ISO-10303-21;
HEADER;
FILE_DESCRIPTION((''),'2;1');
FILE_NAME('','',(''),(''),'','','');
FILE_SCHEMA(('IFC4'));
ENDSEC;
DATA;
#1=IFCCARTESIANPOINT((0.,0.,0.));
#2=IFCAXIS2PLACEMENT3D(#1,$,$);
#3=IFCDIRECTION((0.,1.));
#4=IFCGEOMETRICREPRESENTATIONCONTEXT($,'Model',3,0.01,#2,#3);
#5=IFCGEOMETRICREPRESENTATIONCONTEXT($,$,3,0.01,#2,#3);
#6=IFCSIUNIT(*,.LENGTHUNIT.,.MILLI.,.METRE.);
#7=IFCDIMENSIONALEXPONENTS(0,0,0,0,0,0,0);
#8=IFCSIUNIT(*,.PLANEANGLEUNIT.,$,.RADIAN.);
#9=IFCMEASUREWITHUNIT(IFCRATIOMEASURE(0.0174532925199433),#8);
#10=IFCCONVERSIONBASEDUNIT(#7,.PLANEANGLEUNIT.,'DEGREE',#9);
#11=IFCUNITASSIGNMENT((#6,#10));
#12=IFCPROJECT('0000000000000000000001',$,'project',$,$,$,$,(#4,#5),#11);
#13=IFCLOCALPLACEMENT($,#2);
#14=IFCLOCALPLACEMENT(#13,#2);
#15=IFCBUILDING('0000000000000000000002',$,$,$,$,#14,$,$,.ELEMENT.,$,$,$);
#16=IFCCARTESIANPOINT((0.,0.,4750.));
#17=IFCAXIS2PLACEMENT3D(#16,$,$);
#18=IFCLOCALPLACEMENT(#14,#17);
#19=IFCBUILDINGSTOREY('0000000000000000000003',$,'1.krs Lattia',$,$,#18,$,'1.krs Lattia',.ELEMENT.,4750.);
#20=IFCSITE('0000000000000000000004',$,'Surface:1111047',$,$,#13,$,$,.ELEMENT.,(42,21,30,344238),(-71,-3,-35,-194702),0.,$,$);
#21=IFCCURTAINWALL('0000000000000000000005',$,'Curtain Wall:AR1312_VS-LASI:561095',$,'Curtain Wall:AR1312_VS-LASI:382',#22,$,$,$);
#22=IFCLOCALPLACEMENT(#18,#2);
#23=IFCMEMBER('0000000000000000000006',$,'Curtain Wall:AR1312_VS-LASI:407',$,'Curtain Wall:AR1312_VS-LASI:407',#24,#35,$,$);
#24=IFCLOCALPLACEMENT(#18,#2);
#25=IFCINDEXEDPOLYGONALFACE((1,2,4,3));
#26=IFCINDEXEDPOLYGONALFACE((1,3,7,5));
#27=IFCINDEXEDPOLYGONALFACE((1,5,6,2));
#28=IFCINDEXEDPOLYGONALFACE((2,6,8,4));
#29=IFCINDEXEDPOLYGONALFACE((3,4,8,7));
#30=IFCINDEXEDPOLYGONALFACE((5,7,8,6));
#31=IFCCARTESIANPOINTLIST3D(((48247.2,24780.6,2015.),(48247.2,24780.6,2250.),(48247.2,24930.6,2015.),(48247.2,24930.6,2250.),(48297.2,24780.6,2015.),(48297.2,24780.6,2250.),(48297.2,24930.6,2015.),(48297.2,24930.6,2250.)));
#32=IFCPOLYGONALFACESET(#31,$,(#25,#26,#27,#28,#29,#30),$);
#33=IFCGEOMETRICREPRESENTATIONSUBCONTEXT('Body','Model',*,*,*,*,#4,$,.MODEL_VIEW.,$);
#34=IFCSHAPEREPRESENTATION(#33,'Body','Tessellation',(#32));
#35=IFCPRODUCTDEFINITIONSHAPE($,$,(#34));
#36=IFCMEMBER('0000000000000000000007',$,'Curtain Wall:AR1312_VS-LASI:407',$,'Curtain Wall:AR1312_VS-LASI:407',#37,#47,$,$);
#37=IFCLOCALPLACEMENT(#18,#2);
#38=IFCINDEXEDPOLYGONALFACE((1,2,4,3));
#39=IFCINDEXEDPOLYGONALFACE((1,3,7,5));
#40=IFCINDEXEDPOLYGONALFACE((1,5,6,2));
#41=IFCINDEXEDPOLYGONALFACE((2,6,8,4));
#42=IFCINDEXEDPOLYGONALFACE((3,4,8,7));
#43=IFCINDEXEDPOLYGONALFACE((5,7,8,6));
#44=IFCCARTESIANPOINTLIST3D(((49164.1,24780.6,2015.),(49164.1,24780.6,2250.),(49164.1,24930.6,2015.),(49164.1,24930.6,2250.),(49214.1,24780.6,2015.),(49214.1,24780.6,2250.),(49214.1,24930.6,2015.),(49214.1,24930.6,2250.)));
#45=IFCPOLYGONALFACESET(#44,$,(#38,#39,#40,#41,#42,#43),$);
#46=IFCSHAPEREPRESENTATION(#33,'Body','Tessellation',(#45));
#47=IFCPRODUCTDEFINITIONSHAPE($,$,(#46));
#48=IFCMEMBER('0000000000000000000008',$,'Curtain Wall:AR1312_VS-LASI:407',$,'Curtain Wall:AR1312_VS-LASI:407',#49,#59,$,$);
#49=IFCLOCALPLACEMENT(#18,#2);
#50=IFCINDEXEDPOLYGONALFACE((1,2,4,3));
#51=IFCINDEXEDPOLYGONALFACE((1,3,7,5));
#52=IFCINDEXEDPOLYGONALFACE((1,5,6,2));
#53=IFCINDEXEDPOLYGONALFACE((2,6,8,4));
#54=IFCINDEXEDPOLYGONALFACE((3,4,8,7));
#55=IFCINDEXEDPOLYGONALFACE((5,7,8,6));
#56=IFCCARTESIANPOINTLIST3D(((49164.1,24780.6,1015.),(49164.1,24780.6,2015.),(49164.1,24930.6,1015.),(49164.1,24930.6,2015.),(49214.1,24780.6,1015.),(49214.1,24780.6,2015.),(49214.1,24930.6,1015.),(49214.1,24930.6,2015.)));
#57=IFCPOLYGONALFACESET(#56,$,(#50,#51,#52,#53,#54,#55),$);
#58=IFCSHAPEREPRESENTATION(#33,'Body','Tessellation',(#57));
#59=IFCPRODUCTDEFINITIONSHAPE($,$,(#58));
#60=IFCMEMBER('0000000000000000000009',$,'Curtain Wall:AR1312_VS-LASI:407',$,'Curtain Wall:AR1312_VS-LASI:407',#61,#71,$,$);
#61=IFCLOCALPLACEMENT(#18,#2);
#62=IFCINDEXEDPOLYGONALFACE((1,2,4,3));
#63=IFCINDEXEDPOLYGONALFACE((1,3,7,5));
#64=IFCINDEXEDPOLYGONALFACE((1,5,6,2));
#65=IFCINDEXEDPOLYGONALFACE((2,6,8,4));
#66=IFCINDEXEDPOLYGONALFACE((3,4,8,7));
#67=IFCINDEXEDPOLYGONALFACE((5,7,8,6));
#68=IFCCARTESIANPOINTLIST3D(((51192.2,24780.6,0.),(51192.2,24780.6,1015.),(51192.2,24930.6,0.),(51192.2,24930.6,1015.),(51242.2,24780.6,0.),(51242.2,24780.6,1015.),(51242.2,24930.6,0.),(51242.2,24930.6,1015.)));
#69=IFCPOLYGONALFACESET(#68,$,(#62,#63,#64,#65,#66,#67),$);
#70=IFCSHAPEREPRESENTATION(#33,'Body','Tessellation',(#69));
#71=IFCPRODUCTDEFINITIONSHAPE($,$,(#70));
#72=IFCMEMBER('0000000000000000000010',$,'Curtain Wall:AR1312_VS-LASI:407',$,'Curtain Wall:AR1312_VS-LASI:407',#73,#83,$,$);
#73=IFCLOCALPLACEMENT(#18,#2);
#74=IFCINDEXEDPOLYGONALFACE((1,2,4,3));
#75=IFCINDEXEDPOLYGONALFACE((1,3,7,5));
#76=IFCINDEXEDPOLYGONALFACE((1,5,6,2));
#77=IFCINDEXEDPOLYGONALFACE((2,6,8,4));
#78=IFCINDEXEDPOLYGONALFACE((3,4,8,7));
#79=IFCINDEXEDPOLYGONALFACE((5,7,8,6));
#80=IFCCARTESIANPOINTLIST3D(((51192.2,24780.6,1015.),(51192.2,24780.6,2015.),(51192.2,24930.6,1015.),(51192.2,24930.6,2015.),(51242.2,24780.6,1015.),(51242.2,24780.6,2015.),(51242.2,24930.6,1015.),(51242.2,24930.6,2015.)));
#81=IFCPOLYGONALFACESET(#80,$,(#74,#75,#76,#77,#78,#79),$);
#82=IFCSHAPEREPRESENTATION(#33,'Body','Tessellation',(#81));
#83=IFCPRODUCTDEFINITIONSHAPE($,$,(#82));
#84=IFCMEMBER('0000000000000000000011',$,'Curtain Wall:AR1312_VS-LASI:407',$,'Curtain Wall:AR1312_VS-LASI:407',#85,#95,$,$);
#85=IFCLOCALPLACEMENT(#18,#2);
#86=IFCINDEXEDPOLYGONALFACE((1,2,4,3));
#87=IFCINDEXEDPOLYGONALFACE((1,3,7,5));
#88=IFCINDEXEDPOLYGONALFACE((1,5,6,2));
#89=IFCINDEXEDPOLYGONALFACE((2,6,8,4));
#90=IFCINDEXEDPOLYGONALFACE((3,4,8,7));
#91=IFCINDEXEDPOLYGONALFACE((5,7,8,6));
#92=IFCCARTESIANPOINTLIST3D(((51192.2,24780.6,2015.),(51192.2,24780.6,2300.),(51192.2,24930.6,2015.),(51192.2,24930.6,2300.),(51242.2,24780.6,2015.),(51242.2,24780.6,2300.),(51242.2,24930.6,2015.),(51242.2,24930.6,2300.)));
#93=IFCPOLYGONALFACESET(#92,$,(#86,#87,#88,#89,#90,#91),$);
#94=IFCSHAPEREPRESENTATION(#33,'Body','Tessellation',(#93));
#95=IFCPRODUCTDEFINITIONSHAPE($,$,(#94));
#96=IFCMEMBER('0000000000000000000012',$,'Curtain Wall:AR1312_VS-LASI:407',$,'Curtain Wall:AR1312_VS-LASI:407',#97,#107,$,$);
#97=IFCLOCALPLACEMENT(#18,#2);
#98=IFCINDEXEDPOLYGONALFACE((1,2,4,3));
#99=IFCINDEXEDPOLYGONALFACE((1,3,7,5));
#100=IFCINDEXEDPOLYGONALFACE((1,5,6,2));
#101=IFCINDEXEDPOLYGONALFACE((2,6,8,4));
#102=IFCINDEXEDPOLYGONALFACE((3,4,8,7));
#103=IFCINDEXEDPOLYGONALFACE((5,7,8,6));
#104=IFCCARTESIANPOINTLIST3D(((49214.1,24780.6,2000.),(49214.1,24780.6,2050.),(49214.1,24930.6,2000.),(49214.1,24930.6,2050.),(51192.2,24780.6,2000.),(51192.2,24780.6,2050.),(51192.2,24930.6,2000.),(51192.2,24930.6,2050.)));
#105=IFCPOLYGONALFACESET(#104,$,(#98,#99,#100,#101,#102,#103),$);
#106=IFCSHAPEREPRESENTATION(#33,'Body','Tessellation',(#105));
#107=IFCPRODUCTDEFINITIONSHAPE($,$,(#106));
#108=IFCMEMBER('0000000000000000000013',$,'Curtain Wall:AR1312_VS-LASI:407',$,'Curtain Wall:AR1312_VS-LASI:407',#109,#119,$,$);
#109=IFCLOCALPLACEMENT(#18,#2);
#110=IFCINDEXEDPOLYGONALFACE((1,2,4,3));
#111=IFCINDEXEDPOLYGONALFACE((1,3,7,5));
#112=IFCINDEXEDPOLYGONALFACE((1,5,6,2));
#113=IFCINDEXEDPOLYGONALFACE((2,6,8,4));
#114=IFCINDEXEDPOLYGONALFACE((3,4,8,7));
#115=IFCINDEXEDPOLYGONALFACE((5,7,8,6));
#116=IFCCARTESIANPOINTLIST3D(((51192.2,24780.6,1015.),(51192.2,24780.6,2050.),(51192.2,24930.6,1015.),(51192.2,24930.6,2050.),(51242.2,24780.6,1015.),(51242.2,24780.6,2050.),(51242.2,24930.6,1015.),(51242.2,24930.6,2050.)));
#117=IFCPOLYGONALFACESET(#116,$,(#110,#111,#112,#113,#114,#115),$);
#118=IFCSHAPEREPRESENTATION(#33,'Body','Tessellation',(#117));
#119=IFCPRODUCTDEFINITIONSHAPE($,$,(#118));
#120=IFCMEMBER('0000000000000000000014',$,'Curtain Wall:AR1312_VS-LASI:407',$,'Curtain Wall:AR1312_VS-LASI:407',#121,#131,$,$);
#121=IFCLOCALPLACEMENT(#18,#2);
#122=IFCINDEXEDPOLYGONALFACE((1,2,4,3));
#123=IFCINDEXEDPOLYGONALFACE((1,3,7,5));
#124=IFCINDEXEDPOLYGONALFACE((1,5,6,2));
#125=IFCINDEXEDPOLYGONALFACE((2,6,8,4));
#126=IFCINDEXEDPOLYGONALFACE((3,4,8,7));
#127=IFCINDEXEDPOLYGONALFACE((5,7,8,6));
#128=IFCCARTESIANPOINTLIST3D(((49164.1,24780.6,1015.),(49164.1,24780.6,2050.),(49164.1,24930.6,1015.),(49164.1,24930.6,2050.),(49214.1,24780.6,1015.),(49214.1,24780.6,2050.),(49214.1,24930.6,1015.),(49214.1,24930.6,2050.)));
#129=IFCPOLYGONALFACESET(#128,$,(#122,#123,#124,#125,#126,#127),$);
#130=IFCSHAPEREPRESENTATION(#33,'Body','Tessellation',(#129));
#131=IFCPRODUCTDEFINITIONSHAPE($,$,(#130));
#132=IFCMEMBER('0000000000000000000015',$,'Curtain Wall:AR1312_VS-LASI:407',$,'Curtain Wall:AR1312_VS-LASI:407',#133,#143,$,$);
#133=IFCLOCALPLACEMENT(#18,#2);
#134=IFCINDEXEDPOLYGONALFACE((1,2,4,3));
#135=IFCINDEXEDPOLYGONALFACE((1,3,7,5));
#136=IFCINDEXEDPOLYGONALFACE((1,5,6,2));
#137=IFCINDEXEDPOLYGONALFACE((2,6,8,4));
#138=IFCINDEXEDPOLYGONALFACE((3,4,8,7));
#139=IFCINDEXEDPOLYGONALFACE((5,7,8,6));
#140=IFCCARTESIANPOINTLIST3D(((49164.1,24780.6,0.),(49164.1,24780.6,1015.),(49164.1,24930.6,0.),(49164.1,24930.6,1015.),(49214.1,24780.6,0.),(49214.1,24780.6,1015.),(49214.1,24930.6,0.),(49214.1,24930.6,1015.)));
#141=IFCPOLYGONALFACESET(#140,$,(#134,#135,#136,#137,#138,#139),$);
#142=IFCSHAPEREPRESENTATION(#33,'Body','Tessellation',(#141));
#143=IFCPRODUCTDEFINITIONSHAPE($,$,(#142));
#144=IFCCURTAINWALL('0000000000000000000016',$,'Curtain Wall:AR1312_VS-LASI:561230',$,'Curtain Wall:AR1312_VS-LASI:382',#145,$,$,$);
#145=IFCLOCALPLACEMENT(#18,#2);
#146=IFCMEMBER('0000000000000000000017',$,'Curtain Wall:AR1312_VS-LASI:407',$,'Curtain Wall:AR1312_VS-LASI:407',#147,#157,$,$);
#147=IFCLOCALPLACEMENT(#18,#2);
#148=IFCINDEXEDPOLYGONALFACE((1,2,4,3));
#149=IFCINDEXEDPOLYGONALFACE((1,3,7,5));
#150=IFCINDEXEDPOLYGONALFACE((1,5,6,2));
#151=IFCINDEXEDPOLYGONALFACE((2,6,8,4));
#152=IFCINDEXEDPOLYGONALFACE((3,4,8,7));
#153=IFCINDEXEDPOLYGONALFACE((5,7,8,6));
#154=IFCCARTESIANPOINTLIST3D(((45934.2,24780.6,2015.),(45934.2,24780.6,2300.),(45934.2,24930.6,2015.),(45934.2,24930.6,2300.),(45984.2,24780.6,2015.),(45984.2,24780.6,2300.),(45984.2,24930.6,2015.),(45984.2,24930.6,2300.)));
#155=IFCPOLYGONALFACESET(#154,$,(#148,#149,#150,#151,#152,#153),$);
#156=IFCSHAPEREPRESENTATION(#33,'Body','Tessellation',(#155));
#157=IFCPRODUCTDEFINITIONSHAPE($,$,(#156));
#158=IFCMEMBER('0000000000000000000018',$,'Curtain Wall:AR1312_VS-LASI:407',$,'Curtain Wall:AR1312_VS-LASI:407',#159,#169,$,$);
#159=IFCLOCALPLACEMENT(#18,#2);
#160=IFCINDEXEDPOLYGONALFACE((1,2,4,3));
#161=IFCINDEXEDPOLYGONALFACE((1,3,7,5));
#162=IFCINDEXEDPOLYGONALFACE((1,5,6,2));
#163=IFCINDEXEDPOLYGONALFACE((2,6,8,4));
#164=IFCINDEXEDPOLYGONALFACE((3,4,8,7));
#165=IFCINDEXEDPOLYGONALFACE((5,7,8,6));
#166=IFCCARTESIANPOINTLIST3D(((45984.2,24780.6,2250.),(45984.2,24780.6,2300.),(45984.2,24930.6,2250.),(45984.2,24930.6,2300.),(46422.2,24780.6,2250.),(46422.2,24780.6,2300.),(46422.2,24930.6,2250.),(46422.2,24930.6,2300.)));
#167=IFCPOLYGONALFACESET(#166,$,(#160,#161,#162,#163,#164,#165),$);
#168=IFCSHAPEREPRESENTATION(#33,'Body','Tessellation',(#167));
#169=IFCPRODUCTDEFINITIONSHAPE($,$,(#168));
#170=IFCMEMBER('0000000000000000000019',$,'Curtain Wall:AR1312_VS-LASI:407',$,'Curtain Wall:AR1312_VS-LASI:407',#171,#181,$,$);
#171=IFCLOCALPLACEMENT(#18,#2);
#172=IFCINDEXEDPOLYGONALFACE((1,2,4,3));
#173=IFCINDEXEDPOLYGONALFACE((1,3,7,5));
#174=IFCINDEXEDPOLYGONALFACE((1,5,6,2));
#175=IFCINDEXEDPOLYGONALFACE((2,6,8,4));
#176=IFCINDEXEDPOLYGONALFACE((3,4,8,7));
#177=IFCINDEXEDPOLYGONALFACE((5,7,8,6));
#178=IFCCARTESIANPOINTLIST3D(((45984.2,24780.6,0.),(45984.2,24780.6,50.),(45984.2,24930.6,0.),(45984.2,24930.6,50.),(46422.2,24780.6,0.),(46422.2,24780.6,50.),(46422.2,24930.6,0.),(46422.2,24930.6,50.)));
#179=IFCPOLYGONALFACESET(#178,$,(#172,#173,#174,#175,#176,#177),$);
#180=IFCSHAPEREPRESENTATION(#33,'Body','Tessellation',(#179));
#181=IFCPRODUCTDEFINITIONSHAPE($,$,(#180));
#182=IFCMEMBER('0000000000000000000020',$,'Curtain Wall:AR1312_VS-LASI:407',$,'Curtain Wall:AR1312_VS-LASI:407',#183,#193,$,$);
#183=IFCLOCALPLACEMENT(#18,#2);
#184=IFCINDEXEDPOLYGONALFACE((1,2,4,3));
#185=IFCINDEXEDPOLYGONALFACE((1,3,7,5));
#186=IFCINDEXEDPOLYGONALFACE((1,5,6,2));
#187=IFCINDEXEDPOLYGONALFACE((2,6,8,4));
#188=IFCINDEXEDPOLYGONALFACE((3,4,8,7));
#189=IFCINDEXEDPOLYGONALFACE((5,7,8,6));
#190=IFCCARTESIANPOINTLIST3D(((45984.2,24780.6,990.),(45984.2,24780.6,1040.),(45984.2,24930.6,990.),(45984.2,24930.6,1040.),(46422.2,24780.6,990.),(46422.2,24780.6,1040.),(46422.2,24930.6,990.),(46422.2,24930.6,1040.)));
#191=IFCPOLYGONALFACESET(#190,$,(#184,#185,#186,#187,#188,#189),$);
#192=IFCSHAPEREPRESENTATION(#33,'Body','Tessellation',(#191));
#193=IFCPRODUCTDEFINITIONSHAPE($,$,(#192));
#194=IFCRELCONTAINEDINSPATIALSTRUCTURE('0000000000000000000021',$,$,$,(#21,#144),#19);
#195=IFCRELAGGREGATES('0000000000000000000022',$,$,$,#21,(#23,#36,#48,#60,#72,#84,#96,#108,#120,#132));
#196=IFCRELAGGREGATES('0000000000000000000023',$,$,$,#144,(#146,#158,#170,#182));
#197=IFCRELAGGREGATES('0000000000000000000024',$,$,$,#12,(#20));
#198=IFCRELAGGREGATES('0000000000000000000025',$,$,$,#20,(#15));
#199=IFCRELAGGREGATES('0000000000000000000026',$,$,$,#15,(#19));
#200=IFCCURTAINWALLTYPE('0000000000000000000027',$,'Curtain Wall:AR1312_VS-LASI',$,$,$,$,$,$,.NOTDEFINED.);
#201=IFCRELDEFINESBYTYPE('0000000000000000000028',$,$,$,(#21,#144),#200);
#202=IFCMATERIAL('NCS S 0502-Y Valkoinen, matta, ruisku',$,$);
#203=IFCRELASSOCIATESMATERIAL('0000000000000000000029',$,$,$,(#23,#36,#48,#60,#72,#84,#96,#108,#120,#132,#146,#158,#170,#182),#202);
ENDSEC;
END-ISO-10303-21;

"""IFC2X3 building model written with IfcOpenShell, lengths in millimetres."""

from ifc_helpers import new_model, entity, si_unit, converted_unit, direction, frame, frame_2d, origin, origin_2d_with_axis, place, context, subcontext, project, spatial, rectangle, extrude, material, type_object, element, aggregate, save


model = new_model("IFC2X3")

# Units and contexts
model_context = context("Model", 3, precision=0.01, world=origin(), true_north=direction((0.0, 1.0)))
context_of_model = context(None, 3, precision=0.01, world=origin(), true_north=direction((0.0, 1.0)))
body_context = subcontext(model_context, "Body", "Model", "MODEL_VIEW")
ifc_project = project(units=[si_unit("LENGTHUNIT", "METRE", prefix="MILLI"), converted_unit("PLANEANGLEUNIT", "DEGREE", entity("IfcRatioMeasure", 0.0174532925199433), si_unit("PLANEANGLEUNIT", "RADIAN"), dimensions=[0, 0, 0, 0, 0, 0, 0])], contexts=[model_context, context_of_model])

# Site, building, storey
site_placement = place(None, origin())
site = spatial("IfcSite", under=ifc_project, at=site_placement, Name="Surface:1111047", CompositionType="ELEMENT", RefLatitude=(42, 21, 30, 344238), RefLongitude=(-71, -3, -35, -194702), RefElevation=0.0)
building_placement = place(site_placement, origin())
building = spatial("IfcBuilding", under=site, at=building_placement, CompositionType="ELEMENT")
storey_placement = place(building_placement, frame((0.0, 0.0, 4750.0)))
storey = spatial("IfcBuildingStorey", under=building, at=storey_placement, Name="1.krs Lattia", LongName="1.krs Lattia", CompositionType="ELEMENT", Elevation=4750.0)

# Curtain walls, members
curtain_wall_type = type_object("IfcCurtainWallType", Name="Curtain Wall:AR1312_VS-LASI", PredefinedType="NOTDEFINED")
curtain_wall_1_placement = place(storey_placement, frame((0.0, 0.0, -4750.0)))
curtain_wall_1 = element("IfcCurtainWall", 1, at=curtain_wall_1_placement, inside=storey, type_object=curtain_wall_type, Name="Curtain Wall:AR1312_VS-LASI:561095", ObjectType="Curtain Wall:AR1312_VS-LASI:382")
ifc_material = material(Name="NCS S 0502-Y Valkoinen, matta, ruisku")
member_1_placement = place(curtain_wall_1_placement, frame((0.0, 0.0, 4750.0)))
member_1 = element("IfcMember", 2, at=member_1_placement, material=ifc_material, Name="Curtain Wall:AR1312_VS-LASI:407", ObjectType="Curtain Wall:AR1312_VS-LASI:407", context=body_context, shape_type="SweptSolid", body=[
    extrude(rectangle(XDim=50.0, YDim=150.0, at=frame_2d((0.0, 0.0), x_axis=(1.0, 0.0))), frame((48272.2, 24855.6, 2015.0), z_axis=(0.0, 0.0, 1.0), x_axis=(-1.0, 0.0, 0.0)), (0.0, 0.0, 1.0), 235.0),
])
member_2_placement = place(curtain_wall_1_placement, frame((0.0, 0.0, 4750.0)))
member_2 = element("IfcMember", 3, at=member_2_placement, material=ifc_material, Name="Curtain Wall:AR1312_VS-LASI:407", ObjectType="Curtain Wall:AR1312_VS-LASI:407", context=body_context, shape_type="SweptSolid", body=[
    extrude(rectangle(XDim=50.0, YDim=150.0, at=frame_2d((0.0, 0.0), x_axis=(1.0, 0.0))), frame((49189.1, 24855.6, 2015.0), z_axis=(0.0, 0.0, 1.0), x_axis=(-1.0, 0.0, 0.0)), (0.0, 0.0, 1.0), 235.0),
])
member_3_placement = place(curtain_wall_1_placement, frame((0.0, 0.0, 4750.0)))
member_3 = element("IfcMember", 4, at=member_3_placement, material=ifc_material, Name="Curtain Wall:AR1312_VS-LASI:407", ObjectType="Curtain Wall:AR1312_VS-LASI:407", context=body_context, shape_type="SweptSolid", body=[
    extrude(rectangle(XDim=50.0, YDim=150.0, at=frame_2d((0.0, 0.0), x_axis=(1.0, 0.0))), frame((49189.1, 24855.6, 1015.0), z_axis=(0.0, 0.0, 1.0), x_axis=(-1.0, 0.0, 0.0)), (0.0, 0.0, 1.0), 1000.0),
])
member_4_placement = place(curtain_wall_1_placement, frame((0.0, 0.0, 4750.0)))
member_4 = element("IfcMember", 5, at=member_4_placement, material=ifc_material, Name="Curtain Wall:AR1312_VS-LASI:407", ObjectType="Curtain Wall:AR1312_VS-LASI:407", context=body_context, shape_type="SweptSolid", body=[
    extrude(rectangle(XDim=50.0, YDim=150.0, at=frame_2d((0.0, 0.0), x_axis=(1.0, 0.0))), frame((51217.2, 24855.6, 1015.0), z_axis=(0.0, 0.0, -1.0), x_axis=(-1.0, 0.0, 0.0)), (0.0, 0.0, 1.0), 1015.0),
])
member_5_placement = place(curtain_wall_1_placement, frame((0.0, 0.0, 4750.0)))
member_5 = element("IfcMember", 6, at=member_5_placement, material=ifc_material, Name="Curtain Wall:AR1312_VS-LASI:407", ObjectType="Curtain Wall:AR1312_VS-LASI:407", context=body_context, shape_type="SweptSolid", body=[
    extrude(rectangle(XDim=50.0, YDim=150.0, at=frame_2d((0.0, 0.0), x_axis=(1.0, 0.0))), frame((51217.2, 24855.6, 2015.0), z_axis=(0.0, 0.0, -1.0), x_axis=(-1.0, 0.0, 0.0)), (0.0, 0.0, 1.0), 1000.0),
])
member_6_placement = place(curtain_wall_1_placement, frame((0.0, 0.0, 4750.0)))
member_6 = element("IfcMember", 7, at=member_6_placement, material=ifc_material, Name="Curtain Wall:AR1312_VS-LASI:407", ObjectType="Curtain Wall:AR1312_VS-LASI:407", context=body_context, shape_type="SweptSolid", body=[
    extrude(rectangle(XDim=50.0, YDim=150.0, at=frame_2d((0.0, 0.0), x_axis=(1.0, 0.0))), frame((51217.2, 24855.6, 2300.0), z_axis=(0.0, 0.0, -1.0), x_axis=(-1.0, 0.0, 0.0)), (0.0, 0.0, 1.0), 285.0),
])
member_7_placement = place(curtain_wall_1_placement, frame((0.0, 0.0, 4750.0)))
member_7 = element("IfcMember", 8, at=member_7_placement, material=ifc_material, Name="Curtain Wall:AR1312_VS-LASI:407", ObjectType="Curtain Wall:AR1312_VS-LASI:407", context=body_context, shape_type="SweptSolid", body=[
    extrude(rectangle(XDim=50.0, YDim=150.0, at=frame_2d((0.0, 0.0), x_axis=(1.0, 0.0))), frame((51192.2, 24855.6, 2025.0), z_axis=(-1.0, 0.0, 0.0), x_axis=(0.0, 0.0, -1.0)), (0.0, 0.0, 1.0), 1978.1),
])
member_8_placement = place(curtain_wall_1_placement, frame((0.0, 0.0, 4750.0)))
member_8 = element("IfcMember", 9, at=member_8_placement, material=ifc_material, Name="Curtain Wall:AR1312_VS-LASI:407", ObjectType="Curtain Wall:AR1312_VS-LASI:407", context=body_context, shape_type="SweptSolid", body=[
    extrude(rectangle(XDim=50.0, YDim=150.0, at=frame_2d((0.0, 0.0), x_axis=(1.0, 0.0))), frame((51217.2, 24855.6, 1015.0), z_axis=(0.0, 0.0, 1.0), x_axis=(-1.0, 0.0, 0.0)), (0.0, 0.0, 1.0), 1035.0),
])
member_9_placement = place(curtain_wall_1_placement, frame((0.0, 0.0, 4750.0)))
member_9 = element("IfcMember", 10, at=member_9_placement, material=ifc_material, Name="Curtain Wall:AR1312_VS-LASI:407", ObjectType="Curtain Wall:AR1312_VS-LASI:407", context=body_context, shape_type="SweptSolid", body=[
    extrude(rectangle(XDim=50.0, YDim=150.0, at=frame_2d((0.0, 0.0), x_axis=(1.0, 0.0))), frame((49189.1, 24855.6, 2050.0), z_axis=(0.0, 0.0, -1.0), x_axis=(-1.0, 0.0, 0.0)), (0.0, 0.0, 1.0), 1035.0),
])
member_10_placement = place(curtain_wall_1_placement, frame((0.0, 0.0, 4750.0)))
member_10 = element("IfcMember", 11, at=member_10_placement, material=ifc_material, Name="Curtain Wall:AR1312_VS-LASI:407", ObjectType="Curtain Wall:AR1312_VS-LASI:407", context=body_context, shape_type="SweptSolid", body=[
    extrude(rectangle(XDim=50.0, YDim=150.0, at=frame_2d((0.0, 0.0), x_axis=(1.0, 0.0))), frame((49189.1, 24855.6, 1015.0), z_axis=(0.0, 0.0, -1.0), x_axis=(-1.0, 0.0, 0.0)), (0.0, 0.0, 1.0), 1015.0),
])
aggregate(curtain_wall_1, [member_1, member_2, member_3, member_4, member_5, member_6, member_7, member_8, member_9, member_10])
curtain_wall_2_placement = place(storey_placement, frame((0.0, 0.0, -4750.0)))
curtain_wall_2 = element("IfcCurtainWall", 12, at=curtain_wall_2_placement, inside=storey, type_object=curtain_wall_type, Name="Curtain Wall:AR1312_VS-LASI:561230", ObjectType="Curtain Wall:AR1312_VS-LASI:382")
member_11_placement = place(curtain_wall_2_placement, frame((0.0, 0.0, 4750.0)))
member_11 = element("IfcMember", 13, at=member_11_placement, material=ifc_material, Name="Curtain Wall:AR1312_VS-LASI:407", ObjectType="Curtain Wall:AR1312_VS-LASI:407", context=body_context, shape_type="SweptSolid", body=[
    extrude(rectangle(XDim=50.0, YDim=150.0, at=frame_2d((0.0, 0.0), x_axis=(1.0, 0.0))), frame((45959.2, 24855.6, 2300.0), z_axis=(0.0, 0.0, -1.0), x_axis=(-1.0, 0.0, 0.0)), (0.0, 0.0, 1.0), 285.0),
])
member_12_placement = place(curtain_wall_2_placement, frame((0.0, 0.0, 4750.0)))
member_12 = element("IfcMember", 14, at=member_12_placement, material=ifc_material, Name="Curtain Wall:AR1312_VS-LASI:407", ObjectType="Curtain Wall:AR1312_VS-LASI:407", context=body_context, shape_type="SweptSolid", body=[
    extrude(rectangle(XDim=50.0, YDim=150.0, at=origin_2d_with_axis()), frame((46422.2, 24855.6, 2275.0), z_axis=(-1.0, 0.0, 0.0), x_axis=(0.0, 0.0, -1.0)), (0.0, 0.0, 1.0), 438.0),
])
member_13_placement = place(curtain_wall_2_placement, frame((0.0, 0.0, 4750.0)))
member_13 = element("IfcMember", 15, at=member_13_placement, material=ifc_material, Name="Curtain Wall:AR1312_VS-LASI:407", ObjectType="Curtain Wall:AR1312_VS-LASI:407", context=body_context, shape_type="SweptSolid", body=[
    extrude(rectangle(XDim=50.0, YDim=150.0, at=frame_2d((0.0, 0.0), x_axis=(1.0, 0.0))), frame((45984.2, 24855.6, 25.0), z_axis=(1.0, 0.0, 0.0), x_axis=(0.0, 0.0, -1.0)), (0.0, 0.0, 1.0), 438.0),
])
member_14_placement = place(curtain_wall_2_placement, frame((0.0, 0.0, 4750.0)))
member_14 = element("IfcMember", 16, at=member_14_placement, material=ifc_material, Name="Curtain Wall:AR1312_VS-LASI:407", ObjectType="Curtain Wall:AR1312_VS-LASI:407", context=body_context, shape_type="SweptSolid", body=[
    extrude(rectangle(XDim=50.0, YDim=150.0, at=origin_2d_with_axis()), frame((46422.2, 24855.6, 1015.0), z_axis=(-1.0, 0.0, 0.0), x_axis=(0.0, 0.0, -1.0)), (0.0, 0.0, 1.0), 438.0),
])
aggregate(curtain_wall_2, [member_11, member_12, member_13, member_14])

save(model, "model.ifc")
